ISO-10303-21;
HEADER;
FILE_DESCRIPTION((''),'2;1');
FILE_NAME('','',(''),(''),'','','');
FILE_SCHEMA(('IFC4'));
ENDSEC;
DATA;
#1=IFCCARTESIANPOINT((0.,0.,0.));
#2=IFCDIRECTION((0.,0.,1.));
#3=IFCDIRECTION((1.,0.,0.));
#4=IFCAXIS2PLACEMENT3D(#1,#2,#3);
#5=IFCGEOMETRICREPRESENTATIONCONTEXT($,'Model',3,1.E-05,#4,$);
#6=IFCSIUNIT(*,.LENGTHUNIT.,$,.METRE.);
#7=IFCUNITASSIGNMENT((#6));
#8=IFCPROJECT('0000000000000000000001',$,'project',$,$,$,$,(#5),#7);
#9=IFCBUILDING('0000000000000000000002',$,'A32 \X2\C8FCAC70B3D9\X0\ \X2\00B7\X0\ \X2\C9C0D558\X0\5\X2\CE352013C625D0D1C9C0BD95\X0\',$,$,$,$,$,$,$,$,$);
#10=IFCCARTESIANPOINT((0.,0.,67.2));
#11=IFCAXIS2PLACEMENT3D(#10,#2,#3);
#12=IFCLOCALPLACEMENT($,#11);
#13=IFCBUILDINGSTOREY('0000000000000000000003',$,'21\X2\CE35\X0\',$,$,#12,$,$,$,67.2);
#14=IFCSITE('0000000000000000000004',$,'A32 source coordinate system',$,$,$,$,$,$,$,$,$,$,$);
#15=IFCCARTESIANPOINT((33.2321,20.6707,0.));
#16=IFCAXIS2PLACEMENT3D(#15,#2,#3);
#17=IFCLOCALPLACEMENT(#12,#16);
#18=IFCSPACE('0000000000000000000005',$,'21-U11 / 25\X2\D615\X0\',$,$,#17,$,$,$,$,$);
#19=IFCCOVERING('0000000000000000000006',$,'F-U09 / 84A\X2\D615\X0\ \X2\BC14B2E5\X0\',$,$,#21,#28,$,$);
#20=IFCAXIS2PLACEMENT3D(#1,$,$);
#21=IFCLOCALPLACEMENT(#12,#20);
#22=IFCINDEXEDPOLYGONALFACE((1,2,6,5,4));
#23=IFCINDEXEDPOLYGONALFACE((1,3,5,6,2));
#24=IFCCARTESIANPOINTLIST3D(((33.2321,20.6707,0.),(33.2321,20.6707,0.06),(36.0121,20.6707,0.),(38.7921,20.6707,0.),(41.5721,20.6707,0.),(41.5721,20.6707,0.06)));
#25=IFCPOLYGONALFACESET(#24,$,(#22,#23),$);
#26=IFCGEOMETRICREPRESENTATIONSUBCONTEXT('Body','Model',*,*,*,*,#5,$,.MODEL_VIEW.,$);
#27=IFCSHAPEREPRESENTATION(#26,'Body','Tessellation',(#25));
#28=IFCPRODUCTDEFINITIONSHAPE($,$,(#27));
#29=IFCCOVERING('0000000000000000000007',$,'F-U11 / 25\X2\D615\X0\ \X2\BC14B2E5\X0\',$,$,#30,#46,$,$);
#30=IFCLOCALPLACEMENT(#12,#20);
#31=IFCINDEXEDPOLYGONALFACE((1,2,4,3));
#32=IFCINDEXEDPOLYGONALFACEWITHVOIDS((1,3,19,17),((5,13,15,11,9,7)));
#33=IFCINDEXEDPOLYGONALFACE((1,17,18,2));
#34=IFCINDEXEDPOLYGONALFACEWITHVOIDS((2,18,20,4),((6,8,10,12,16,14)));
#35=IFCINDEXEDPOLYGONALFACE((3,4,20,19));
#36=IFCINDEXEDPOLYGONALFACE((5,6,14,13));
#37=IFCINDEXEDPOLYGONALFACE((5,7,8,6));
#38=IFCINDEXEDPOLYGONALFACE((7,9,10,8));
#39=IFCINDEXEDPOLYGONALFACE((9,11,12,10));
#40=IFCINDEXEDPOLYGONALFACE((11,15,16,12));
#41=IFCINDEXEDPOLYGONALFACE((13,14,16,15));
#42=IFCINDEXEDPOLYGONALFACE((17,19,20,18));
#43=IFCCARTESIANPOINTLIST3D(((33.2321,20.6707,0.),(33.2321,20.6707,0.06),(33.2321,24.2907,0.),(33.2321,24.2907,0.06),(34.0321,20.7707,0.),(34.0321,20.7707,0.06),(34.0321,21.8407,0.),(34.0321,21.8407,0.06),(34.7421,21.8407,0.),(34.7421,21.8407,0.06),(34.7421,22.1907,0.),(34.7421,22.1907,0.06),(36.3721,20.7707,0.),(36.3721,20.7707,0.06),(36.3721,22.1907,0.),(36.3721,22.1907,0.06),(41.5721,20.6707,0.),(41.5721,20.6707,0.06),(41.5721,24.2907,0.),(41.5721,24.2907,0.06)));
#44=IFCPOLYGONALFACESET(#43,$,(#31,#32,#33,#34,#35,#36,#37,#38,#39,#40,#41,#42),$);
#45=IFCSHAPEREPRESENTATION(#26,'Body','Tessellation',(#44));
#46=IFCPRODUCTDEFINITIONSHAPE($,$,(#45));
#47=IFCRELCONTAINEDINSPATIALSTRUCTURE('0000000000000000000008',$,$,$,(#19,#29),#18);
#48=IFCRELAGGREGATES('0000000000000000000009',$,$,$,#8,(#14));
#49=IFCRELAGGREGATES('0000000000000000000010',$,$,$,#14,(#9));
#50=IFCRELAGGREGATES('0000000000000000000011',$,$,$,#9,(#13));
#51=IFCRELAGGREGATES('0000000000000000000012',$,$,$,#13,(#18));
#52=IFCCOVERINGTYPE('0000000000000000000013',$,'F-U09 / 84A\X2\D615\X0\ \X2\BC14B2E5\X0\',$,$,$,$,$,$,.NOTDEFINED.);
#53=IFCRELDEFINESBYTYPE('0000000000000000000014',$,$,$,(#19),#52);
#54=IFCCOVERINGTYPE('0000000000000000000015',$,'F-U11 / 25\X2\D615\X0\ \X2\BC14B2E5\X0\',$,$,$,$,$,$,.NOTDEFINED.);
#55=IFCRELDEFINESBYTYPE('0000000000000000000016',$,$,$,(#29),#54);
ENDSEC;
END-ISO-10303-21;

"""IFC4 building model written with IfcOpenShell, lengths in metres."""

from ifc_helpers import new_model, si_unit, frame, origin, origin_with_axes, place, context, subcontext, project, spatial, polyline, outline, extrude, source, transform, mapped, type_object, type_shapes, element, save


model = new_model("IFC4")

# Units and contexts
model_context = context("Model", 3, precision=1e-05, world=origin_with_axes())
body_context = subcontext(model_context, "Body", "Model", "MODEL_VIEW")
ifc_project = project(units=[si_unit("LENGTHUNIT", "METRE")], contexts=[model_context])

# Site, building, storey
site = spatial("IfcSite", under=ifc_project, Name="A32 source coordinate system")
building = spatial("IfcBuilding", under=site, Name="A32 주거동 · 지하5층–옥탑지붕")
storey_placement = place(None, frame((0.0, 0.0, 67.2), z_axis=(0.0, 0.0, 1.0), x_axis=(1.0, 0.0, 0.0)))
storey = spatial("IfcBuildingStorey", under=building, at=storey_placement, Name="21층", Elevation=67.2)

# Shared definitions
space_1_placement = place(storey_placement, frame((33.2321, 20.6707, 0.0), z_axis=(0.0, 0.0, 1.0), x_axis=(1.0, 0.0, 0.0)))
space_1 = spatial("IfcSpace", under=storey, at=space_1_placement, Name="21-U11 / 25형")

# Coverings
covering_type_1 = type_object("IfcCoveringType", Name="F-U09 / 84A형 바닥", PredefinedType="NOTDEFINED")
shared_shape_1 = source(origin(), body_context, "Body", "SweptSolid", [
    extrude(outline(polyline([(0.0, 0.0), (8.34, 0.0), (8.34, 0.0), (0.0, 0.0), (0.0, 0.0)])), origin(), (0.0, 0.0, 1.0), 0.06),
])
type_shapes(covering_type_1, [shared_shape_1])
covering_1_placement = place(space_1_placement, origin_with_axes())
element("IfcCovering", 1, at=covering_1_placement, inside=space_1, type_object=covering_type_1, Name="F-U09 / 84A형 바닥", context=body_context, shape_type="MappedRepresentation", body=[
    mapped(shared_shape_1, transform((0.0, 0.0, 0.0), scale=1.0)),
])
covering_type_2 = type_object("IfcCoveringType", Name="F-U11 / 25형 바닥", PredefinedType="NOTDEFINED")
shared_shape_2 = source(origin(), body_context, "Body", "SweptSolid", [
    extrude(outline(polyline([(0.0, 0.0), (0.0, 3.62), (8.34, 3.62), (8.34, 0.0), (0.0, 0.0)]), holes=[polyline([(1.51, 1.17), (0.8, 1.17), (0.8, 0.1), (3.14, 0.1), (3.14, 1.52), (1.51, 1.52), (1.51, 1.17)])]), origin(), (0.0, 0.0, 1.0), 0.06),
])
type_shapes(covering_type_2, [shared_shape_2])
covering_2_placement = place(space_1_placement, origin_with_axes())
element("IfcCovering", 2, at=covering_2_placement, inside=space_1, type_object=covering_type_2, Name="F-U11 / 25형 바닥", context=body_context, shape_type="MappedRepresentation", body=[
    mapped(shared_shape_2, transform((0.0, 0.0, 0.0), scale=1.0)),
])

save(model, "model.ifc")
